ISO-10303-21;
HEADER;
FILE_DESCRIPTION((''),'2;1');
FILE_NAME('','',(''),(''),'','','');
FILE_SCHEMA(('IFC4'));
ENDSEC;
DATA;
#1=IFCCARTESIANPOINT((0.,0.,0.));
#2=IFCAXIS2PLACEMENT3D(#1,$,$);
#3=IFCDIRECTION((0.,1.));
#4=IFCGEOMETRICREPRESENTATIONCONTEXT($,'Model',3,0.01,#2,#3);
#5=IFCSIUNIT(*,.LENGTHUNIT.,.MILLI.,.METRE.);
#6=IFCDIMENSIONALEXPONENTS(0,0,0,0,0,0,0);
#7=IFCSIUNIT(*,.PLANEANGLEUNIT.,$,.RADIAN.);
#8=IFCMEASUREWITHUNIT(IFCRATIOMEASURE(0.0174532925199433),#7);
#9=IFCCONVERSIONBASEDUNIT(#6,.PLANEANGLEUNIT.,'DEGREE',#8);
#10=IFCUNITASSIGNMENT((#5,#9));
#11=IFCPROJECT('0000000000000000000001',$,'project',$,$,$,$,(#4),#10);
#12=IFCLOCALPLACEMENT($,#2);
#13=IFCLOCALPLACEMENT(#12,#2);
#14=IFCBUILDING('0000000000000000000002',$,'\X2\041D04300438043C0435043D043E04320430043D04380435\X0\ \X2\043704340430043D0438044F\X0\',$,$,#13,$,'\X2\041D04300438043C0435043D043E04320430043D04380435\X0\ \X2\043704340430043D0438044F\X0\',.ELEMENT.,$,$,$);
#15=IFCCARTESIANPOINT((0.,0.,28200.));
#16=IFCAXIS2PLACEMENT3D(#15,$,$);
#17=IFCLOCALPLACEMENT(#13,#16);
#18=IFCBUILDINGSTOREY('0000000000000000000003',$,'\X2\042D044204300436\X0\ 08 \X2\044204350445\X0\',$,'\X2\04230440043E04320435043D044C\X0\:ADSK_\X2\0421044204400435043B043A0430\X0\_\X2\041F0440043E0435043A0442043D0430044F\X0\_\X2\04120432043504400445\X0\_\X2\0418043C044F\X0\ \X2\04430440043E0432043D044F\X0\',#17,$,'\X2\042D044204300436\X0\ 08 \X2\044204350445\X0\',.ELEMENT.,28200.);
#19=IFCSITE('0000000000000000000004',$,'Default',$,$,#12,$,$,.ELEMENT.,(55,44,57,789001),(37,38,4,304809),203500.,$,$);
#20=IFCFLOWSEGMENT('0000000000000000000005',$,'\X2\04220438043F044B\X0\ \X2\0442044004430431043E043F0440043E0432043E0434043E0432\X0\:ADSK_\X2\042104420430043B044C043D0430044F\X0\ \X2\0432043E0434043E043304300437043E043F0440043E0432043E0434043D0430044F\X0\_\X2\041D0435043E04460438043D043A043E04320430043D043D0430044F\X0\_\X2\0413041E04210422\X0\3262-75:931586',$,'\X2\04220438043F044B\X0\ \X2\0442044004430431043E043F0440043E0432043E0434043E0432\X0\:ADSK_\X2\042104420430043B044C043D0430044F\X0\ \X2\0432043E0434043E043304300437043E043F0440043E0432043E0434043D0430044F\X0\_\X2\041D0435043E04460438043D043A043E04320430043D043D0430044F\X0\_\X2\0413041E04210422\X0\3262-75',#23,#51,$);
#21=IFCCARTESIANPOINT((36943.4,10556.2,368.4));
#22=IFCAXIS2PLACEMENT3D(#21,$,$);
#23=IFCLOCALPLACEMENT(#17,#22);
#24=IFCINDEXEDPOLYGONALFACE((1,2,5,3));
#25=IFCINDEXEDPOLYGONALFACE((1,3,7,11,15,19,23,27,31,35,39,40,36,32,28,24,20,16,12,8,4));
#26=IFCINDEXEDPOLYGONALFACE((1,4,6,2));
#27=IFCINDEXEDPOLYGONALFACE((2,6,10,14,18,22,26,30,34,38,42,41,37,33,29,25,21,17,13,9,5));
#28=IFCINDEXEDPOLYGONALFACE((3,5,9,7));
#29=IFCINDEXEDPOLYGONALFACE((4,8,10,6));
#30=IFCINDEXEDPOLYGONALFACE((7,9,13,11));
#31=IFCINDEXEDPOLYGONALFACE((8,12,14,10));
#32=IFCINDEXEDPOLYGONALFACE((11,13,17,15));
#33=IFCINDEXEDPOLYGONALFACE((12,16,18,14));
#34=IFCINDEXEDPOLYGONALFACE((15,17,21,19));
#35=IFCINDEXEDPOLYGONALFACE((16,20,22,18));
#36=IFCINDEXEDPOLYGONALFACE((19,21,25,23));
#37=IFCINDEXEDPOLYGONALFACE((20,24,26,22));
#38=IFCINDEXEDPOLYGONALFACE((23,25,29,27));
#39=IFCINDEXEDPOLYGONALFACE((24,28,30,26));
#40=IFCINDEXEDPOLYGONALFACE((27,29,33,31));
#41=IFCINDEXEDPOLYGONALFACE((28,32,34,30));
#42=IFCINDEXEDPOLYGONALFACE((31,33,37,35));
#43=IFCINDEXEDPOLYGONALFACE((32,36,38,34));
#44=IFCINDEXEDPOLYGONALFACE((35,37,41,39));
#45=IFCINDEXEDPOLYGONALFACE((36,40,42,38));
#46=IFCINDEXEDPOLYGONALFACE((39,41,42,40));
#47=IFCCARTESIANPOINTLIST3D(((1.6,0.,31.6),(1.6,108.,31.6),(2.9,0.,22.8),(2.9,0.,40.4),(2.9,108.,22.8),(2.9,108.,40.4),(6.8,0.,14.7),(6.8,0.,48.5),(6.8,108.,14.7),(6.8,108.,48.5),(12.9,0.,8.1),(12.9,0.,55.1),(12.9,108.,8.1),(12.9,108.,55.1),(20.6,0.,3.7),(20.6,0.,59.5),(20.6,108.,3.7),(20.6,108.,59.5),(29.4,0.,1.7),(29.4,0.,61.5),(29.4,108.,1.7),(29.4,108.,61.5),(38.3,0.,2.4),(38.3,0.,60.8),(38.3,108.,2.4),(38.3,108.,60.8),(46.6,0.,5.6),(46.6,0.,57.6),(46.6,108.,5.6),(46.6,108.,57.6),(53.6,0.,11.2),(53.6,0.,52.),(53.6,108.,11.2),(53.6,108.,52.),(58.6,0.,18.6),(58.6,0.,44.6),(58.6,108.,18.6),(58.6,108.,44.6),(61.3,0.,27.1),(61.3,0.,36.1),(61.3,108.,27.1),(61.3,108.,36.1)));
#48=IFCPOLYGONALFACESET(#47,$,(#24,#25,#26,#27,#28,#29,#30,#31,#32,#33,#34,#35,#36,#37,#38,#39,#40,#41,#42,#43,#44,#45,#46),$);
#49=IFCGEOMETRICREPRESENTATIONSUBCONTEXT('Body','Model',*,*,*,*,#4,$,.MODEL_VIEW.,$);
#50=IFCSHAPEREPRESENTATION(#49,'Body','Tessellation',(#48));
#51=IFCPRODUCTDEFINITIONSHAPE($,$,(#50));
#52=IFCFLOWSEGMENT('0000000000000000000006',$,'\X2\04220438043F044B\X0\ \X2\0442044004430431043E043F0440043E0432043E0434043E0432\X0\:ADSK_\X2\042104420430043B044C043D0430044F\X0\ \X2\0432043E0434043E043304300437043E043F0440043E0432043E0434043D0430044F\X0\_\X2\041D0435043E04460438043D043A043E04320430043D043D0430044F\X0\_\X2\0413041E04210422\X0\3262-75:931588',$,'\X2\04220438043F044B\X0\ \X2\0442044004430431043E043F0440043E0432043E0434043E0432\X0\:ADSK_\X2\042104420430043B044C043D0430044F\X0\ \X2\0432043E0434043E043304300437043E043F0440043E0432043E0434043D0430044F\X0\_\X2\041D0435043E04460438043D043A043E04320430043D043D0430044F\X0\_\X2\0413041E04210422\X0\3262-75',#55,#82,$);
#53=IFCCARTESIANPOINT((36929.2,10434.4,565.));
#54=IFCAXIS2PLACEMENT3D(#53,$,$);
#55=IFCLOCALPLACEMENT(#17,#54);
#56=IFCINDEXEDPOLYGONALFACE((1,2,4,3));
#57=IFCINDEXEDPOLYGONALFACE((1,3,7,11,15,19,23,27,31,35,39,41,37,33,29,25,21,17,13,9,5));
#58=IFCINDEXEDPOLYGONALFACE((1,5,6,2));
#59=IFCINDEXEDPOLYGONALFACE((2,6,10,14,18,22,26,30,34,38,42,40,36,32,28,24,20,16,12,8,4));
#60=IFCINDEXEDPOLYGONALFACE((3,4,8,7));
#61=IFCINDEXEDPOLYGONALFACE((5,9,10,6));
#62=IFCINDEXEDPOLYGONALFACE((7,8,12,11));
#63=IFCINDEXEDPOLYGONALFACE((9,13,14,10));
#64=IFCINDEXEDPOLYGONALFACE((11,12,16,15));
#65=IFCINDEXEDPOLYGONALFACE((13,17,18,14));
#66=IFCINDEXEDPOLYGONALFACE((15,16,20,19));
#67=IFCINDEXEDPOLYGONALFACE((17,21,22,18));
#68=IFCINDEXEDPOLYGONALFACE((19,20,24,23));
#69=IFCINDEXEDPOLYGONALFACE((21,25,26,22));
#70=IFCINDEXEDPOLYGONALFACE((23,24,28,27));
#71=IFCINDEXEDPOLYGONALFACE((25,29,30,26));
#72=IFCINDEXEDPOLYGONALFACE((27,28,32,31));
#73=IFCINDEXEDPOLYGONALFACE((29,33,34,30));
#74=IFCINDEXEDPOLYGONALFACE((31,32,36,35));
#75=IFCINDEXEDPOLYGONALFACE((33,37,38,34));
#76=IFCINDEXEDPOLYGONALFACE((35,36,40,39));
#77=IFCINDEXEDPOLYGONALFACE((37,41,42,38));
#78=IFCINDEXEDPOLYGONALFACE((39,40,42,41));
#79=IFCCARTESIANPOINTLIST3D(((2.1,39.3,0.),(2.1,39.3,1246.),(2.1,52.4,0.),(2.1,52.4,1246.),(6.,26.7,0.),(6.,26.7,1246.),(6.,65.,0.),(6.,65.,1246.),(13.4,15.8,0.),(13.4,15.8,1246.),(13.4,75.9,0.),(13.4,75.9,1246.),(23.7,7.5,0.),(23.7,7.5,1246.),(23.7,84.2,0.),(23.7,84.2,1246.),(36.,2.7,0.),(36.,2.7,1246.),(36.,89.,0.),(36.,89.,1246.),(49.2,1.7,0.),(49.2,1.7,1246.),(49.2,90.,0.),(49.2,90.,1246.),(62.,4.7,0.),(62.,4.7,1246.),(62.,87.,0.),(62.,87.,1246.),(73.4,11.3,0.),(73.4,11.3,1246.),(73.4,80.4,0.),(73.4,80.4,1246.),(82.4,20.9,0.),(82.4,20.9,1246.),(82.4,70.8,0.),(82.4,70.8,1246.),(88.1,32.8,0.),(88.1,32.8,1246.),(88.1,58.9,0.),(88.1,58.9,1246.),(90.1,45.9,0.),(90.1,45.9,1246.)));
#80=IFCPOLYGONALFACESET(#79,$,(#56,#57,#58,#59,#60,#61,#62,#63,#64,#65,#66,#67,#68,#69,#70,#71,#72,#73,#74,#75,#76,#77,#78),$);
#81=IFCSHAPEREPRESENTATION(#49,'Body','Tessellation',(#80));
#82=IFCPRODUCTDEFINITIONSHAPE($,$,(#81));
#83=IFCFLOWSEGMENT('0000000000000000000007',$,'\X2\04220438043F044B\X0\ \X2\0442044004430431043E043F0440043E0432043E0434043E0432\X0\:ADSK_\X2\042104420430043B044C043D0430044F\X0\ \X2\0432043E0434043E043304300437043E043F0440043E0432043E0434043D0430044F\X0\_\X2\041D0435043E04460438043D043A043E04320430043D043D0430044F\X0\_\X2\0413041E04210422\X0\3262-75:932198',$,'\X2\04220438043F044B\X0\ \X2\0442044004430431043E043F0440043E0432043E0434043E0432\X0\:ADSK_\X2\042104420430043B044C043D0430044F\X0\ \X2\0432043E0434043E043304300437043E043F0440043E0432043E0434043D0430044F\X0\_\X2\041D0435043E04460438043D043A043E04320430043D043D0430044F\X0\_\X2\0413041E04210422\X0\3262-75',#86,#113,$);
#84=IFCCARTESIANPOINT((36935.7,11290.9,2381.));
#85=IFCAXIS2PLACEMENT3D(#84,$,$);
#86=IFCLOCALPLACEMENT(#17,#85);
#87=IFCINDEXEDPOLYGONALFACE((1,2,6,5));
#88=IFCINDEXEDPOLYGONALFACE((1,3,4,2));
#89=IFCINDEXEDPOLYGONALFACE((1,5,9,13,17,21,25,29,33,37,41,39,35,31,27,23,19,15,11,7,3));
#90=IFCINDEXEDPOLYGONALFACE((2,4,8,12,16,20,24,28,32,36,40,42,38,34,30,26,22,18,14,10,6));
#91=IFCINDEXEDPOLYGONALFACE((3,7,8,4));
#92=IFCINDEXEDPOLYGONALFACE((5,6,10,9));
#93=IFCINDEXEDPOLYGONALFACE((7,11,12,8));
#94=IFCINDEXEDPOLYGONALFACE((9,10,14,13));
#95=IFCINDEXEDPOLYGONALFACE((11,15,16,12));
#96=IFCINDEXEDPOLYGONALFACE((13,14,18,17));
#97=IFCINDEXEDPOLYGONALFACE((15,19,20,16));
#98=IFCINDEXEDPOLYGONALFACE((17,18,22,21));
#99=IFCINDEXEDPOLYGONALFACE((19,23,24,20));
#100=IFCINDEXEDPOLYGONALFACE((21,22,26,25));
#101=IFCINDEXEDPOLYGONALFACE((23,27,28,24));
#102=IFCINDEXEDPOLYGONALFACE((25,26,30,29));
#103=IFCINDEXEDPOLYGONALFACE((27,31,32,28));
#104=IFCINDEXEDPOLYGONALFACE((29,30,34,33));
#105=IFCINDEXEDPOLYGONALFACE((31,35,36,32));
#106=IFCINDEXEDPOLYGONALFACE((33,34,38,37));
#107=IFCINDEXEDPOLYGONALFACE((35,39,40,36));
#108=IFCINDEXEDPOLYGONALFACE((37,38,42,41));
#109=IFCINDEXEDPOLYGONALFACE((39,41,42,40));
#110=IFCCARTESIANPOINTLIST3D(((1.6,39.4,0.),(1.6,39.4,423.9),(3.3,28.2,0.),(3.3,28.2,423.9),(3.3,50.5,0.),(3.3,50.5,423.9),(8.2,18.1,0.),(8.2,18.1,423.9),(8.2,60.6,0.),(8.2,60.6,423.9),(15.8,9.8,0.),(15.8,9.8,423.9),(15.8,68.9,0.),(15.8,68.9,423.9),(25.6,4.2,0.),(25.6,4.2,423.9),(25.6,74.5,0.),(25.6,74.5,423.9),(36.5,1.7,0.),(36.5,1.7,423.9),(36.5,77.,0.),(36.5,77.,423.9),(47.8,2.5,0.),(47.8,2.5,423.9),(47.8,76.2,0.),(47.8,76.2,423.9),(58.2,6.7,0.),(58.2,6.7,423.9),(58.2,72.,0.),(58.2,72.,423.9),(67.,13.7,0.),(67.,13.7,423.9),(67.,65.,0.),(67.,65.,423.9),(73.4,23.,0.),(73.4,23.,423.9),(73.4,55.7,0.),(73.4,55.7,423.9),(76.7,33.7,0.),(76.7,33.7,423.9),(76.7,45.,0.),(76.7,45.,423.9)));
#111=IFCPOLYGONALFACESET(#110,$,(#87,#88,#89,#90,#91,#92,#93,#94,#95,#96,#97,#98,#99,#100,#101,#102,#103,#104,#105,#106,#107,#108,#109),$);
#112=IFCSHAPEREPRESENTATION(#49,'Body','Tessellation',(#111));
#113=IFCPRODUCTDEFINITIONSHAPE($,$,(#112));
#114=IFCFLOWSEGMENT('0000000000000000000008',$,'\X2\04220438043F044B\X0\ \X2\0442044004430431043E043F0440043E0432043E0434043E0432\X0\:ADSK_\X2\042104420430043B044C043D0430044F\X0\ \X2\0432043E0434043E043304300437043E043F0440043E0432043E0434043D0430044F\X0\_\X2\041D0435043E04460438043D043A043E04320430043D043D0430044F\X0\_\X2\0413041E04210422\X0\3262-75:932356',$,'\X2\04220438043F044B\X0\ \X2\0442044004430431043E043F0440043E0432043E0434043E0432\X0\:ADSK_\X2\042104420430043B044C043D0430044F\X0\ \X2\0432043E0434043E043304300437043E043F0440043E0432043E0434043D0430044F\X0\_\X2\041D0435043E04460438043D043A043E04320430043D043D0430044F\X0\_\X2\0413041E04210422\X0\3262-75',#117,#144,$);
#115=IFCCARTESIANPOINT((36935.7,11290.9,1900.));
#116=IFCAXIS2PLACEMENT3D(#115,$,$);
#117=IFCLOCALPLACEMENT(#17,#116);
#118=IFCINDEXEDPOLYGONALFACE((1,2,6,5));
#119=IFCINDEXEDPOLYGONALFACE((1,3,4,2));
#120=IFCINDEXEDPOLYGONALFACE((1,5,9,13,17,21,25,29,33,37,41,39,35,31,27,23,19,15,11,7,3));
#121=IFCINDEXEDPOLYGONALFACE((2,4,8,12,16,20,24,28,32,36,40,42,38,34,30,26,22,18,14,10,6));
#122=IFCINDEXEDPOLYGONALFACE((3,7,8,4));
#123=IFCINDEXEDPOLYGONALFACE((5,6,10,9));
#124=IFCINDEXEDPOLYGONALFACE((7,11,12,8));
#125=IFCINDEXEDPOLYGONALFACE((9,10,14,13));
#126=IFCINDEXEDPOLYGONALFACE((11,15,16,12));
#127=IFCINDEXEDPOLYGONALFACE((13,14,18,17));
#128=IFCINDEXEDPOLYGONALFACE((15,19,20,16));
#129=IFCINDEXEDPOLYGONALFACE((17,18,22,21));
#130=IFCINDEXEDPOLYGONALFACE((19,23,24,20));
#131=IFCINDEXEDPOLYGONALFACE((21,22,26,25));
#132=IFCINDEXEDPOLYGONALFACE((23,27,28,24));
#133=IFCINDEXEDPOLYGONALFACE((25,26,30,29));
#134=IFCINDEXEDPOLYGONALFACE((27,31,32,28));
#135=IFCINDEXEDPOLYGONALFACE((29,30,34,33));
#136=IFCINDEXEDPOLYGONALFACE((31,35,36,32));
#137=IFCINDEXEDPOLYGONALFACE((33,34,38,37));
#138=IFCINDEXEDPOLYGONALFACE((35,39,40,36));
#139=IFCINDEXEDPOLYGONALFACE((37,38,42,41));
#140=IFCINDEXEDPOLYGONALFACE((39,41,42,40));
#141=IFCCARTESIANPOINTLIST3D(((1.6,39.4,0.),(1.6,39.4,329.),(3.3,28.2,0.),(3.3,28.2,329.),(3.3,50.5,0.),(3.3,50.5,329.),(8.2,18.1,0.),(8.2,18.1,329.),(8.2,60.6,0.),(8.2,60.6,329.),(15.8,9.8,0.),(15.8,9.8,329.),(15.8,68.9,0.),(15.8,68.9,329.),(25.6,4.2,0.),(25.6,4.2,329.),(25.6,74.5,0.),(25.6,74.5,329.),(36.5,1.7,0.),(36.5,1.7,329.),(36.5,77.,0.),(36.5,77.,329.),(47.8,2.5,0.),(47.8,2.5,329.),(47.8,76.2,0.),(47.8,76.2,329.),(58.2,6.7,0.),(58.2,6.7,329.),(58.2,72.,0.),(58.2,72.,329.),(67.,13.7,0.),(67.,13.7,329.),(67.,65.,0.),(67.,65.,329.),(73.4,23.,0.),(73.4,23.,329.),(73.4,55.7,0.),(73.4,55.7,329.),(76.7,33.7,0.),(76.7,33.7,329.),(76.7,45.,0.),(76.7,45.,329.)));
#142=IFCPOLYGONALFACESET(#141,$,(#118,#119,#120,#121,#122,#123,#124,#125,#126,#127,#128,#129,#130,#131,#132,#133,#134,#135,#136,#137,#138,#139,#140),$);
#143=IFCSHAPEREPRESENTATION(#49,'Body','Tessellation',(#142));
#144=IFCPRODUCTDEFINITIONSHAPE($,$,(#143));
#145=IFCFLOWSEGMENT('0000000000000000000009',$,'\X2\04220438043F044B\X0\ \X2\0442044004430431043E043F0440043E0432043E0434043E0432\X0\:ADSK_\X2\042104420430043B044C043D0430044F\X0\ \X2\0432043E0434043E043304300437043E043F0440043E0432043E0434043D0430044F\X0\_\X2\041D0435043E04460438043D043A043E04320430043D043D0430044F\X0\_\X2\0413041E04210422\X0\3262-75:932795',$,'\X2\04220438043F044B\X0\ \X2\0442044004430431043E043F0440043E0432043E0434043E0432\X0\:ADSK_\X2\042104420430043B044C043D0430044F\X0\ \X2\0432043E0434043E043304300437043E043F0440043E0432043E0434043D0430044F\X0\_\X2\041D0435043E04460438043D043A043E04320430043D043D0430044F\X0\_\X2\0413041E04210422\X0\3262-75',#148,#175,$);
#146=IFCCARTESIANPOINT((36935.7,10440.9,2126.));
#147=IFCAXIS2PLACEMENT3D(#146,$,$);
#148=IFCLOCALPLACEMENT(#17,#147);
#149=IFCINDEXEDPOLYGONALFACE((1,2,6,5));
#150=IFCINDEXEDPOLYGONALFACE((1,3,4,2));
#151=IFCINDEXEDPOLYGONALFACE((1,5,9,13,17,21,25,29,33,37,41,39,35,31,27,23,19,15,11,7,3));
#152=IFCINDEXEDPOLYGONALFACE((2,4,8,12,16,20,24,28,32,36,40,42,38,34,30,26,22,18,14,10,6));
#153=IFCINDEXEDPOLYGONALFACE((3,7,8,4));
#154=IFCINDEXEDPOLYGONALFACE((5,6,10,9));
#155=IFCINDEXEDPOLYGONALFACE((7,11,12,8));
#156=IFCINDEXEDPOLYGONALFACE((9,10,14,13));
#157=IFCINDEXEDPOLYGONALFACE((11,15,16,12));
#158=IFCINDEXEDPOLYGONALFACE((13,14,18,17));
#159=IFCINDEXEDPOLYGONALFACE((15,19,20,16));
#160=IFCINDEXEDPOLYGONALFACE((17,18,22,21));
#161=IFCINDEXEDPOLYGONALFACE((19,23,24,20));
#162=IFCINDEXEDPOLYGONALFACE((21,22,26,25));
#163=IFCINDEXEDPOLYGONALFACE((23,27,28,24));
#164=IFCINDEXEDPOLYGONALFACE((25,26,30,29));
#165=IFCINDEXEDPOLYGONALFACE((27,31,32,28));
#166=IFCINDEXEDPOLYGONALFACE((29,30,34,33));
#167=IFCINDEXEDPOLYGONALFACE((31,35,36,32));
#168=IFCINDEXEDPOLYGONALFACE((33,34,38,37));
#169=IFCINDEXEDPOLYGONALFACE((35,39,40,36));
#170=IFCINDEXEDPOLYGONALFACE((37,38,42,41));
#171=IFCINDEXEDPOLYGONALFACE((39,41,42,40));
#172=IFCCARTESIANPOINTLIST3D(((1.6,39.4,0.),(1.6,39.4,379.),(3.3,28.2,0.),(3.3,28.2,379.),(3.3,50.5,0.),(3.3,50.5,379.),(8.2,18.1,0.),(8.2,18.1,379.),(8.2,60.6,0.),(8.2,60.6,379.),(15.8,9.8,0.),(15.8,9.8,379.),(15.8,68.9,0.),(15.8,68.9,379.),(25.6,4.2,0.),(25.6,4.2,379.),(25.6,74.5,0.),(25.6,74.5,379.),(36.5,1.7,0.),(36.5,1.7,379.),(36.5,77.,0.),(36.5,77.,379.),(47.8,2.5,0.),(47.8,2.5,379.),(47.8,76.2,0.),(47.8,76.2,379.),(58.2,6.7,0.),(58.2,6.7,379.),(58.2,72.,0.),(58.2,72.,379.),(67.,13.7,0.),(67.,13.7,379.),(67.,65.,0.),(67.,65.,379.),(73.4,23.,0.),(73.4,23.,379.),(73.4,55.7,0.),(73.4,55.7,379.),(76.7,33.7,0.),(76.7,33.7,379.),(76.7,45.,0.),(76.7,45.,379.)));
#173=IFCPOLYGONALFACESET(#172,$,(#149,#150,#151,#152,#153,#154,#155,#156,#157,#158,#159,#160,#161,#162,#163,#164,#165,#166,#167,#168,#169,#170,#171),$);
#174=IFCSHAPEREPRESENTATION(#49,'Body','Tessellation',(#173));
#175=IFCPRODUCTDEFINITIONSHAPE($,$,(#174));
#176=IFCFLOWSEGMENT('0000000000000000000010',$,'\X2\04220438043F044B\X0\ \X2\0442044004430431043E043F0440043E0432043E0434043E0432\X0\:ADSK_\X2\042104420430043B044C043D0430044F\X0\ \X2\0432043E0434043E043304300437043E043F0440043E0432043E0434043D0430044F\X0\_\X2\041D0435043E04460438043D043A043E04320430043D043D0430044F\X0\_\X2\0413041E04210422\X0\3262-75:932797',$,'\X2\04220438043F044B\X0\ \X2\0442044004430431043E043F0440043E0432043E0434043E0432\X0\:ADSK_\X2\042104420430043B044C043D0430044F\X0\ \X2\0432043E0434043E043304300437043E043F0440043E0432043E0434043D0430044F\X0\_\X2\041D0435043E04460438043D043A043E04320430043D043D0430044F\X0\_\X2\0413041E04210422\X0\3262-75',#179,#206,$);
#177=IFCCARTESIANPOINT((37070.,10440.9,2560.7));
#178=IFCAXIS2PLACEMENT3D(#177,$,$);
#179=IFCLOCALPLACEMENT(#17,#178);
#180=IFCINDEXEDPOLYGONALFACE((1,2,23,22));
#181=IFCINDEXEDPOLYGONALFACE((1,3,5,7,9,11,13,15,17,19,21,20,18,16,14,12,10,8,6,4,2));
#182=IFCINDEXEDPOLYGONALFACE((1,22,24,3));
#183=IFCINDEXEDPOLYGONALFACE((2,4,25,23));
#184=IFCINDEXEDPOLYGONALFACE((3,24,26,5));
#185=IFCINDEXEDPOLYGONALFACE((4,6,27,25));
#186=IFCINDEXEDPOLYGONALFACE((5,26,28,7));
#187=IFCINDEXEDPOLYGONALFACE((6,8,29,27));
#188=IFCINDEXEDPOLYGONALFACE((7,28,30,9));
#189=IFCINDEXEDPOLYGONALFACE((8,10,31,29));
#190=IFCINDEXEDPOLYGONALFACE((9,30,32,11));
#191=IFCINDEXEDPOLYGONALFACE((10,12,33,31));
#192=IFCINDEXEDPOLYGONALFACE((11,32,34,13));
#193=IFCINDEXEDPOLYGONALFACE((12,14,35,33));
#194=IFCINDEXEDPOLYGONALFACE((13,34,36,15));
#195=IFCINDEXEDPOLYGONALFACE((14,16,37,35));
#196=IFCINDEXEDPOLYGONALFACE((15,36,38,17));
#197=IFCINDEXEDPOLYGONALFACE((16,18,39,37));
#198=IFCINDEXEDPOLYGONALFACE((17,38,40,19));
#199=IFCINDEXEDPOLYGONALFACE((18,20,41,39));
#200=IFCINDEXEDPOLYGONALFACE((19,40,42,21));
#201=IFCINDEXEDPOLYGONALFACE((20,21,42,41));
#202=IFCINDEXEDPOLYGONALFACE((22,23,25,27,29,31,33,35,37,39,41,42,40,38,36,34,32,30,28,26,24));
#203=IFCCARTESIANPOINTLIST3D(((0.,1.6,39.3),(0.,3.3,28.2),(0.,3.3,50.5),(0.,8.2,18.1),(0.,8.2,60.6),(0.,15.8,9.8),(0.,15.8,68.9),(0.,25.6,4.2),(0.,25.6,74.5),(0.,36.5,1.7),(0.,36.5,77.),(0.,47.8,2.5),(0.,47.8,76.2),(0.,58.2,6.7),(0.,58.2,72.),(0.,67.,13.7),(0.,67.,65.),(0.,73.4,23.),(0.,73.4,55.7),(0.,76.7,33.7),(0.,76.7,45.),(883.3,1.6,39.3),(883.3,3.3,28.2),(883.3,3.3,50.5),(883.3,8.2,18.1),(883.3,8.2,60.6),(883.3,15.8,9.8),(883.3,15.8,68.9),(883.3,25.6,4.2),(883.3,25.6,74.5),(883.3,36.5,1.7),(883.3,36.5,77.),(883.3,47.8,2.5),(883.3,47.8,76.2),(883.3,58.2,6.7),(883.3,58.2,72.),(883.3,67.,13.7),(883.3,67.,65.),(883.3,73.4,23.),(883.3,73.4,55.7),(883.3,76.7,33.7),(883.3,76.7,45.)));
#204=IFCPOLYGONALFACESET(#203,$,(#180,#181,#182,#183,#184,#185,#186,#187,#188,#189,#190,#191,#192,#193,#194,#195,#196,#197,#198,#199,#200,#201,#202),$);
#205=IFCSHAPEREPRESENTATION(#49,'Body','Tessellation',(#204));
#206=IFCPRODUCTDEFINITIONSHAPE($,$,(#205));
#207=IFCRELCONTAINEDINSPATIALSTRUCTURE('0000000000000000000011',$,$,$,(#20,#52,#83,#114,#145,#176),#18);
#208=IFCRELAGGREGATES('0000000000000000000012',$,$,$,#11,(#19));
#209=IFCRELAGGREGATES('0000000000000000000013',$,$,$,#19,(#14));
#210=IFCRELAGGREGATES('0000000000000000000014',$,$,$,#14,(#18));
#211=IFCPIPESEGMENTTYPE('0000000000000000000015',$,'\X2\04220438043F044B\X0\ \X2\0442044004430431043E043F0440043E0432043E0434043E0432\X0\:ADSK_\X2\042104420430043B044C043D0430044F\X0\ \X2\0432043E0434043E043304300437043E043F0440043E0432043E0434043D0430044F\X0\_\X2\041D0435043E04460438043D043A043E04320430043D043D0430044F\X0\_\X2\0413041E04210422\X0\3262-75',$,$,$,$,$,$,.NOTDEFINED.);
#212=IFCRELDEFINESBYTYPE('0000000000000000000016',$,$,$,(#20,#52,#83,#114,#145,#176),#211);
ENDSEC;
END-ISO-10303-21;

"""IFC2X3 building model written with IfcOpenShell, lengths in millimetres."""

from ifc_helpers import new_model, entity, si_unit, converted_unit, direction, frame, origin, origin_2d_with_axis, place, context, subcontext, project, spatial, circle, extrude, type_object, element, save


model = new_model("IFC2X3")

# Units and contexts
model_context = context("Model", 3, precision=0.01, world=origin(), true_north=direction((0.0, 1.0)))
body_context = subcontext(model_context, "Body", "Model", "MODEL_VIEW")
ifc_project = project(units=[si_unit("LENGTHUNIT", "METRE", prefix="MILLI"), converted_unit("PLANEANGLEUNIT", "DEGREE", entity("IfcRatioMeasure", 0.0174532925199433), si_unit("PLANEANGLEUNIT", "RADIAN"), dimensions=[0, 0, 0, 0, 0, 0, 0])], contexts=[model_context])

# Site, building, storey
site_placement = place(None, origin())
site = spatial("IfcSite", under=ifc_project, at=site_placement, Name="Default", CompositionType="ELEMENT", RefLatitude=(55, 44, 57, 789001), RefLongitude=(37, 38, 4, 304809), RefElevation=203500.0)
building_placement = place(site_placement, origin())
building = spatial("IfcBuilding", under=site, at=building_placement, Name="Наименование здания", LongName="Наименование здания", CompositionType="ELEMENT")
storey_placement = place(building_placement, frame((0.0, 0.0, 28200.0)))
storey = spatial("IfcBuildingStorey", under=building, at=storey_placement, Name="Этаж 08 тех", ObjectType="Уровень:ADSK_Стрелка_Проектная_Вверх_Имя уровня", LongName="Этаж 08 тех", CompositionType="ELEMENT", Elevation=28200.0)

# Flow segments
pipe_segment_type_1 = type_object("IfcPipeSegmentType", Name="Типы трубопроводов:ADSK_Стальная водогазопроводная_Неоцинкованная_ГОСТ3262-75", PredefinedType="NOTDEFINED")
flow_segment_1_placement = place(storey_placement, frame((36943.4, 10556.2, 368.4)))
element("IfcFlowSegment", 1, at=flow_segment_1_placement, inside=storey, type_object=pipe_segment_type_1, Name="Типы трубопроводов:ADSK_Стальная водогазопроводная_Неоцинкованная_ГОСТ3262-75:931586", ObjectType="Типы трубопроводов:ADSK_Стальная водогазопроводная_Неоцинкованная_ГОСТ3262-75", context=body_context, shape_type="SweptSolid", body=[
    extrude(circle(Radius=30.0, at=origin_2d_with_axis()), frame((31.6, 0.0, 31.6), z_axis=(0.0, 1.0, 0.0), x_axis=(-1.0, 0.0, 0.0)), (0.0, 0.0, 1.0), 108.0),
])
flow_segment_2_placement = place(storey_placement, frame((36929.2, 10434.4, 565.0)))
element("IfcFlowSegment", 2, at=flow_segment_2_placement, inside=storey, type_object=pipe_segment_type_1, Name="Типы трубопроводов:ADSK_Стальная водогазопроводная_Неоцинкованная_ГОСТ3262-75:931588", ObjectType="Типы трубопроводов:ADSK_Стальная водогазопроводная_Неоцинкованная_ГОСТ3262-75", context=body_context, shape_type="SweptSolid", body=[
    extrude(circle(Radius=44.2, at=origin_2d_with_axis()), frame((45.9, 45.9, 0.0)), (0.0, 0.0, 1.0), 1246.0),
])
flow_segment_3_placement = place(storey_placement, frame((36935.7, 11290.9, 2381.0)))
element("IfcFlowSegment", 3, at=flow_segment_3_placement, inside=storey, type_object=pipe_segment_type_1, Name="Типы трубопроводов:ADSK_Стальная водогазопроводная_Неоцинкованная_ГОСТ3262-75:932198", ObjectType="Типы трубопроводов:ADSK_Стальная водогазопроводная_Неоцинкованная_ГОСТ3262-75", context=body_context, shape_type="SweptSolid", body=[
    extrude(circle(Radius=37.8, at=origin_2d_with_axis()), frame((39.4, 39.4, 0.0), z_axis=(0.0, 0.0, 1.0), x_axis=(-1.0, 0.0, 0.0)), (0.0, 0.0, 1.0), 423.9),
])
flow_segment_4_placement = place(storey_placement, frame((36935.7, 11290.9, 1900.0)))
element("IfcFlowSegment", 4, at=flow_segment_4_placement, inside=storey, type_object=pipe_segment_type_1, Name="Типы трубопроводов:ADSK_Стальная водогазопроводная_Неоцинкованная_ГОСТ3262-75:932356", ObjectType="Типы трубопроводов:ADSK_Стальная водогазопроводная_Неоцинкованная_ГОСТ3262-75", context=body_context, shape_type="SweptSolid", body=[
    extrude(circle(Radius=37.8, at=origin_2d_with_axis()), frame((39.4, 39.4, 0.0), z_axis=(0.0, 0.0, 1.0), x_axis=(-1.0, 0.0, 0.0)), (0.0, 0.0, 1.0), 329.0),
])
flow_segment_5_placement = place(storey_placement, frame((36935.7, 10440.9, 2126.0)))
element("IfcFlowSegment", 5, at=flow_segment_5_placement, inside=storey, type_object=pipe_segment_type_1, Name="Типы трубопроводов:ADSK_Стальная водогазопроводная_Неоцинкованная_ГОСТ3262-75:932795", ObjectType="Типы трубопроводов:ADSK_Стальная водогазопроводная_Неоцинкованная_ГОСТ3262-75", context=body_context, shape_type="SweptSolid", body=[
    extrude(circle(Radius=37.8, at=origin_2d_with_axis()), frame((39.4, 39.4, 0.0), z_axis=(0.0, 0.0, 1.0), x_axis=(-1.0, 0.0, 0.0)), (0.0, 0.0, 1.0), 379.0),
])
flow_segment_6_placement = place(storey_placement, frame((37070.0, 10440.9, 2560.7)))
element("IfcFlowSegment", 6, at=flow_segment_6_placement, inside=storey, type_object=pipe_segment_type_1, Name="Типы трубопроводов:ADSK_Стальная водогазопроводная_Неоцинкованная_ГОСТ3262-75:932797", ObjectType="Типы трубопроводов:ADSK_Стальная водогазопроводная_Неоцинкованная_ГОСТ3262-75", context=body_context, shape_type="SweptSolid", body=[
    extrude(circle(Radius=37.8, at=origin_2d_with_axis()), frame((0.0, 39.4, 39.4), z_axis=(1.0, 0.0, 0.0), x_axis=(0.0, -1.0, 0.0)), (0.0, 0.0, 1.0), 883.3),
])

save(model, "model.ifc")
